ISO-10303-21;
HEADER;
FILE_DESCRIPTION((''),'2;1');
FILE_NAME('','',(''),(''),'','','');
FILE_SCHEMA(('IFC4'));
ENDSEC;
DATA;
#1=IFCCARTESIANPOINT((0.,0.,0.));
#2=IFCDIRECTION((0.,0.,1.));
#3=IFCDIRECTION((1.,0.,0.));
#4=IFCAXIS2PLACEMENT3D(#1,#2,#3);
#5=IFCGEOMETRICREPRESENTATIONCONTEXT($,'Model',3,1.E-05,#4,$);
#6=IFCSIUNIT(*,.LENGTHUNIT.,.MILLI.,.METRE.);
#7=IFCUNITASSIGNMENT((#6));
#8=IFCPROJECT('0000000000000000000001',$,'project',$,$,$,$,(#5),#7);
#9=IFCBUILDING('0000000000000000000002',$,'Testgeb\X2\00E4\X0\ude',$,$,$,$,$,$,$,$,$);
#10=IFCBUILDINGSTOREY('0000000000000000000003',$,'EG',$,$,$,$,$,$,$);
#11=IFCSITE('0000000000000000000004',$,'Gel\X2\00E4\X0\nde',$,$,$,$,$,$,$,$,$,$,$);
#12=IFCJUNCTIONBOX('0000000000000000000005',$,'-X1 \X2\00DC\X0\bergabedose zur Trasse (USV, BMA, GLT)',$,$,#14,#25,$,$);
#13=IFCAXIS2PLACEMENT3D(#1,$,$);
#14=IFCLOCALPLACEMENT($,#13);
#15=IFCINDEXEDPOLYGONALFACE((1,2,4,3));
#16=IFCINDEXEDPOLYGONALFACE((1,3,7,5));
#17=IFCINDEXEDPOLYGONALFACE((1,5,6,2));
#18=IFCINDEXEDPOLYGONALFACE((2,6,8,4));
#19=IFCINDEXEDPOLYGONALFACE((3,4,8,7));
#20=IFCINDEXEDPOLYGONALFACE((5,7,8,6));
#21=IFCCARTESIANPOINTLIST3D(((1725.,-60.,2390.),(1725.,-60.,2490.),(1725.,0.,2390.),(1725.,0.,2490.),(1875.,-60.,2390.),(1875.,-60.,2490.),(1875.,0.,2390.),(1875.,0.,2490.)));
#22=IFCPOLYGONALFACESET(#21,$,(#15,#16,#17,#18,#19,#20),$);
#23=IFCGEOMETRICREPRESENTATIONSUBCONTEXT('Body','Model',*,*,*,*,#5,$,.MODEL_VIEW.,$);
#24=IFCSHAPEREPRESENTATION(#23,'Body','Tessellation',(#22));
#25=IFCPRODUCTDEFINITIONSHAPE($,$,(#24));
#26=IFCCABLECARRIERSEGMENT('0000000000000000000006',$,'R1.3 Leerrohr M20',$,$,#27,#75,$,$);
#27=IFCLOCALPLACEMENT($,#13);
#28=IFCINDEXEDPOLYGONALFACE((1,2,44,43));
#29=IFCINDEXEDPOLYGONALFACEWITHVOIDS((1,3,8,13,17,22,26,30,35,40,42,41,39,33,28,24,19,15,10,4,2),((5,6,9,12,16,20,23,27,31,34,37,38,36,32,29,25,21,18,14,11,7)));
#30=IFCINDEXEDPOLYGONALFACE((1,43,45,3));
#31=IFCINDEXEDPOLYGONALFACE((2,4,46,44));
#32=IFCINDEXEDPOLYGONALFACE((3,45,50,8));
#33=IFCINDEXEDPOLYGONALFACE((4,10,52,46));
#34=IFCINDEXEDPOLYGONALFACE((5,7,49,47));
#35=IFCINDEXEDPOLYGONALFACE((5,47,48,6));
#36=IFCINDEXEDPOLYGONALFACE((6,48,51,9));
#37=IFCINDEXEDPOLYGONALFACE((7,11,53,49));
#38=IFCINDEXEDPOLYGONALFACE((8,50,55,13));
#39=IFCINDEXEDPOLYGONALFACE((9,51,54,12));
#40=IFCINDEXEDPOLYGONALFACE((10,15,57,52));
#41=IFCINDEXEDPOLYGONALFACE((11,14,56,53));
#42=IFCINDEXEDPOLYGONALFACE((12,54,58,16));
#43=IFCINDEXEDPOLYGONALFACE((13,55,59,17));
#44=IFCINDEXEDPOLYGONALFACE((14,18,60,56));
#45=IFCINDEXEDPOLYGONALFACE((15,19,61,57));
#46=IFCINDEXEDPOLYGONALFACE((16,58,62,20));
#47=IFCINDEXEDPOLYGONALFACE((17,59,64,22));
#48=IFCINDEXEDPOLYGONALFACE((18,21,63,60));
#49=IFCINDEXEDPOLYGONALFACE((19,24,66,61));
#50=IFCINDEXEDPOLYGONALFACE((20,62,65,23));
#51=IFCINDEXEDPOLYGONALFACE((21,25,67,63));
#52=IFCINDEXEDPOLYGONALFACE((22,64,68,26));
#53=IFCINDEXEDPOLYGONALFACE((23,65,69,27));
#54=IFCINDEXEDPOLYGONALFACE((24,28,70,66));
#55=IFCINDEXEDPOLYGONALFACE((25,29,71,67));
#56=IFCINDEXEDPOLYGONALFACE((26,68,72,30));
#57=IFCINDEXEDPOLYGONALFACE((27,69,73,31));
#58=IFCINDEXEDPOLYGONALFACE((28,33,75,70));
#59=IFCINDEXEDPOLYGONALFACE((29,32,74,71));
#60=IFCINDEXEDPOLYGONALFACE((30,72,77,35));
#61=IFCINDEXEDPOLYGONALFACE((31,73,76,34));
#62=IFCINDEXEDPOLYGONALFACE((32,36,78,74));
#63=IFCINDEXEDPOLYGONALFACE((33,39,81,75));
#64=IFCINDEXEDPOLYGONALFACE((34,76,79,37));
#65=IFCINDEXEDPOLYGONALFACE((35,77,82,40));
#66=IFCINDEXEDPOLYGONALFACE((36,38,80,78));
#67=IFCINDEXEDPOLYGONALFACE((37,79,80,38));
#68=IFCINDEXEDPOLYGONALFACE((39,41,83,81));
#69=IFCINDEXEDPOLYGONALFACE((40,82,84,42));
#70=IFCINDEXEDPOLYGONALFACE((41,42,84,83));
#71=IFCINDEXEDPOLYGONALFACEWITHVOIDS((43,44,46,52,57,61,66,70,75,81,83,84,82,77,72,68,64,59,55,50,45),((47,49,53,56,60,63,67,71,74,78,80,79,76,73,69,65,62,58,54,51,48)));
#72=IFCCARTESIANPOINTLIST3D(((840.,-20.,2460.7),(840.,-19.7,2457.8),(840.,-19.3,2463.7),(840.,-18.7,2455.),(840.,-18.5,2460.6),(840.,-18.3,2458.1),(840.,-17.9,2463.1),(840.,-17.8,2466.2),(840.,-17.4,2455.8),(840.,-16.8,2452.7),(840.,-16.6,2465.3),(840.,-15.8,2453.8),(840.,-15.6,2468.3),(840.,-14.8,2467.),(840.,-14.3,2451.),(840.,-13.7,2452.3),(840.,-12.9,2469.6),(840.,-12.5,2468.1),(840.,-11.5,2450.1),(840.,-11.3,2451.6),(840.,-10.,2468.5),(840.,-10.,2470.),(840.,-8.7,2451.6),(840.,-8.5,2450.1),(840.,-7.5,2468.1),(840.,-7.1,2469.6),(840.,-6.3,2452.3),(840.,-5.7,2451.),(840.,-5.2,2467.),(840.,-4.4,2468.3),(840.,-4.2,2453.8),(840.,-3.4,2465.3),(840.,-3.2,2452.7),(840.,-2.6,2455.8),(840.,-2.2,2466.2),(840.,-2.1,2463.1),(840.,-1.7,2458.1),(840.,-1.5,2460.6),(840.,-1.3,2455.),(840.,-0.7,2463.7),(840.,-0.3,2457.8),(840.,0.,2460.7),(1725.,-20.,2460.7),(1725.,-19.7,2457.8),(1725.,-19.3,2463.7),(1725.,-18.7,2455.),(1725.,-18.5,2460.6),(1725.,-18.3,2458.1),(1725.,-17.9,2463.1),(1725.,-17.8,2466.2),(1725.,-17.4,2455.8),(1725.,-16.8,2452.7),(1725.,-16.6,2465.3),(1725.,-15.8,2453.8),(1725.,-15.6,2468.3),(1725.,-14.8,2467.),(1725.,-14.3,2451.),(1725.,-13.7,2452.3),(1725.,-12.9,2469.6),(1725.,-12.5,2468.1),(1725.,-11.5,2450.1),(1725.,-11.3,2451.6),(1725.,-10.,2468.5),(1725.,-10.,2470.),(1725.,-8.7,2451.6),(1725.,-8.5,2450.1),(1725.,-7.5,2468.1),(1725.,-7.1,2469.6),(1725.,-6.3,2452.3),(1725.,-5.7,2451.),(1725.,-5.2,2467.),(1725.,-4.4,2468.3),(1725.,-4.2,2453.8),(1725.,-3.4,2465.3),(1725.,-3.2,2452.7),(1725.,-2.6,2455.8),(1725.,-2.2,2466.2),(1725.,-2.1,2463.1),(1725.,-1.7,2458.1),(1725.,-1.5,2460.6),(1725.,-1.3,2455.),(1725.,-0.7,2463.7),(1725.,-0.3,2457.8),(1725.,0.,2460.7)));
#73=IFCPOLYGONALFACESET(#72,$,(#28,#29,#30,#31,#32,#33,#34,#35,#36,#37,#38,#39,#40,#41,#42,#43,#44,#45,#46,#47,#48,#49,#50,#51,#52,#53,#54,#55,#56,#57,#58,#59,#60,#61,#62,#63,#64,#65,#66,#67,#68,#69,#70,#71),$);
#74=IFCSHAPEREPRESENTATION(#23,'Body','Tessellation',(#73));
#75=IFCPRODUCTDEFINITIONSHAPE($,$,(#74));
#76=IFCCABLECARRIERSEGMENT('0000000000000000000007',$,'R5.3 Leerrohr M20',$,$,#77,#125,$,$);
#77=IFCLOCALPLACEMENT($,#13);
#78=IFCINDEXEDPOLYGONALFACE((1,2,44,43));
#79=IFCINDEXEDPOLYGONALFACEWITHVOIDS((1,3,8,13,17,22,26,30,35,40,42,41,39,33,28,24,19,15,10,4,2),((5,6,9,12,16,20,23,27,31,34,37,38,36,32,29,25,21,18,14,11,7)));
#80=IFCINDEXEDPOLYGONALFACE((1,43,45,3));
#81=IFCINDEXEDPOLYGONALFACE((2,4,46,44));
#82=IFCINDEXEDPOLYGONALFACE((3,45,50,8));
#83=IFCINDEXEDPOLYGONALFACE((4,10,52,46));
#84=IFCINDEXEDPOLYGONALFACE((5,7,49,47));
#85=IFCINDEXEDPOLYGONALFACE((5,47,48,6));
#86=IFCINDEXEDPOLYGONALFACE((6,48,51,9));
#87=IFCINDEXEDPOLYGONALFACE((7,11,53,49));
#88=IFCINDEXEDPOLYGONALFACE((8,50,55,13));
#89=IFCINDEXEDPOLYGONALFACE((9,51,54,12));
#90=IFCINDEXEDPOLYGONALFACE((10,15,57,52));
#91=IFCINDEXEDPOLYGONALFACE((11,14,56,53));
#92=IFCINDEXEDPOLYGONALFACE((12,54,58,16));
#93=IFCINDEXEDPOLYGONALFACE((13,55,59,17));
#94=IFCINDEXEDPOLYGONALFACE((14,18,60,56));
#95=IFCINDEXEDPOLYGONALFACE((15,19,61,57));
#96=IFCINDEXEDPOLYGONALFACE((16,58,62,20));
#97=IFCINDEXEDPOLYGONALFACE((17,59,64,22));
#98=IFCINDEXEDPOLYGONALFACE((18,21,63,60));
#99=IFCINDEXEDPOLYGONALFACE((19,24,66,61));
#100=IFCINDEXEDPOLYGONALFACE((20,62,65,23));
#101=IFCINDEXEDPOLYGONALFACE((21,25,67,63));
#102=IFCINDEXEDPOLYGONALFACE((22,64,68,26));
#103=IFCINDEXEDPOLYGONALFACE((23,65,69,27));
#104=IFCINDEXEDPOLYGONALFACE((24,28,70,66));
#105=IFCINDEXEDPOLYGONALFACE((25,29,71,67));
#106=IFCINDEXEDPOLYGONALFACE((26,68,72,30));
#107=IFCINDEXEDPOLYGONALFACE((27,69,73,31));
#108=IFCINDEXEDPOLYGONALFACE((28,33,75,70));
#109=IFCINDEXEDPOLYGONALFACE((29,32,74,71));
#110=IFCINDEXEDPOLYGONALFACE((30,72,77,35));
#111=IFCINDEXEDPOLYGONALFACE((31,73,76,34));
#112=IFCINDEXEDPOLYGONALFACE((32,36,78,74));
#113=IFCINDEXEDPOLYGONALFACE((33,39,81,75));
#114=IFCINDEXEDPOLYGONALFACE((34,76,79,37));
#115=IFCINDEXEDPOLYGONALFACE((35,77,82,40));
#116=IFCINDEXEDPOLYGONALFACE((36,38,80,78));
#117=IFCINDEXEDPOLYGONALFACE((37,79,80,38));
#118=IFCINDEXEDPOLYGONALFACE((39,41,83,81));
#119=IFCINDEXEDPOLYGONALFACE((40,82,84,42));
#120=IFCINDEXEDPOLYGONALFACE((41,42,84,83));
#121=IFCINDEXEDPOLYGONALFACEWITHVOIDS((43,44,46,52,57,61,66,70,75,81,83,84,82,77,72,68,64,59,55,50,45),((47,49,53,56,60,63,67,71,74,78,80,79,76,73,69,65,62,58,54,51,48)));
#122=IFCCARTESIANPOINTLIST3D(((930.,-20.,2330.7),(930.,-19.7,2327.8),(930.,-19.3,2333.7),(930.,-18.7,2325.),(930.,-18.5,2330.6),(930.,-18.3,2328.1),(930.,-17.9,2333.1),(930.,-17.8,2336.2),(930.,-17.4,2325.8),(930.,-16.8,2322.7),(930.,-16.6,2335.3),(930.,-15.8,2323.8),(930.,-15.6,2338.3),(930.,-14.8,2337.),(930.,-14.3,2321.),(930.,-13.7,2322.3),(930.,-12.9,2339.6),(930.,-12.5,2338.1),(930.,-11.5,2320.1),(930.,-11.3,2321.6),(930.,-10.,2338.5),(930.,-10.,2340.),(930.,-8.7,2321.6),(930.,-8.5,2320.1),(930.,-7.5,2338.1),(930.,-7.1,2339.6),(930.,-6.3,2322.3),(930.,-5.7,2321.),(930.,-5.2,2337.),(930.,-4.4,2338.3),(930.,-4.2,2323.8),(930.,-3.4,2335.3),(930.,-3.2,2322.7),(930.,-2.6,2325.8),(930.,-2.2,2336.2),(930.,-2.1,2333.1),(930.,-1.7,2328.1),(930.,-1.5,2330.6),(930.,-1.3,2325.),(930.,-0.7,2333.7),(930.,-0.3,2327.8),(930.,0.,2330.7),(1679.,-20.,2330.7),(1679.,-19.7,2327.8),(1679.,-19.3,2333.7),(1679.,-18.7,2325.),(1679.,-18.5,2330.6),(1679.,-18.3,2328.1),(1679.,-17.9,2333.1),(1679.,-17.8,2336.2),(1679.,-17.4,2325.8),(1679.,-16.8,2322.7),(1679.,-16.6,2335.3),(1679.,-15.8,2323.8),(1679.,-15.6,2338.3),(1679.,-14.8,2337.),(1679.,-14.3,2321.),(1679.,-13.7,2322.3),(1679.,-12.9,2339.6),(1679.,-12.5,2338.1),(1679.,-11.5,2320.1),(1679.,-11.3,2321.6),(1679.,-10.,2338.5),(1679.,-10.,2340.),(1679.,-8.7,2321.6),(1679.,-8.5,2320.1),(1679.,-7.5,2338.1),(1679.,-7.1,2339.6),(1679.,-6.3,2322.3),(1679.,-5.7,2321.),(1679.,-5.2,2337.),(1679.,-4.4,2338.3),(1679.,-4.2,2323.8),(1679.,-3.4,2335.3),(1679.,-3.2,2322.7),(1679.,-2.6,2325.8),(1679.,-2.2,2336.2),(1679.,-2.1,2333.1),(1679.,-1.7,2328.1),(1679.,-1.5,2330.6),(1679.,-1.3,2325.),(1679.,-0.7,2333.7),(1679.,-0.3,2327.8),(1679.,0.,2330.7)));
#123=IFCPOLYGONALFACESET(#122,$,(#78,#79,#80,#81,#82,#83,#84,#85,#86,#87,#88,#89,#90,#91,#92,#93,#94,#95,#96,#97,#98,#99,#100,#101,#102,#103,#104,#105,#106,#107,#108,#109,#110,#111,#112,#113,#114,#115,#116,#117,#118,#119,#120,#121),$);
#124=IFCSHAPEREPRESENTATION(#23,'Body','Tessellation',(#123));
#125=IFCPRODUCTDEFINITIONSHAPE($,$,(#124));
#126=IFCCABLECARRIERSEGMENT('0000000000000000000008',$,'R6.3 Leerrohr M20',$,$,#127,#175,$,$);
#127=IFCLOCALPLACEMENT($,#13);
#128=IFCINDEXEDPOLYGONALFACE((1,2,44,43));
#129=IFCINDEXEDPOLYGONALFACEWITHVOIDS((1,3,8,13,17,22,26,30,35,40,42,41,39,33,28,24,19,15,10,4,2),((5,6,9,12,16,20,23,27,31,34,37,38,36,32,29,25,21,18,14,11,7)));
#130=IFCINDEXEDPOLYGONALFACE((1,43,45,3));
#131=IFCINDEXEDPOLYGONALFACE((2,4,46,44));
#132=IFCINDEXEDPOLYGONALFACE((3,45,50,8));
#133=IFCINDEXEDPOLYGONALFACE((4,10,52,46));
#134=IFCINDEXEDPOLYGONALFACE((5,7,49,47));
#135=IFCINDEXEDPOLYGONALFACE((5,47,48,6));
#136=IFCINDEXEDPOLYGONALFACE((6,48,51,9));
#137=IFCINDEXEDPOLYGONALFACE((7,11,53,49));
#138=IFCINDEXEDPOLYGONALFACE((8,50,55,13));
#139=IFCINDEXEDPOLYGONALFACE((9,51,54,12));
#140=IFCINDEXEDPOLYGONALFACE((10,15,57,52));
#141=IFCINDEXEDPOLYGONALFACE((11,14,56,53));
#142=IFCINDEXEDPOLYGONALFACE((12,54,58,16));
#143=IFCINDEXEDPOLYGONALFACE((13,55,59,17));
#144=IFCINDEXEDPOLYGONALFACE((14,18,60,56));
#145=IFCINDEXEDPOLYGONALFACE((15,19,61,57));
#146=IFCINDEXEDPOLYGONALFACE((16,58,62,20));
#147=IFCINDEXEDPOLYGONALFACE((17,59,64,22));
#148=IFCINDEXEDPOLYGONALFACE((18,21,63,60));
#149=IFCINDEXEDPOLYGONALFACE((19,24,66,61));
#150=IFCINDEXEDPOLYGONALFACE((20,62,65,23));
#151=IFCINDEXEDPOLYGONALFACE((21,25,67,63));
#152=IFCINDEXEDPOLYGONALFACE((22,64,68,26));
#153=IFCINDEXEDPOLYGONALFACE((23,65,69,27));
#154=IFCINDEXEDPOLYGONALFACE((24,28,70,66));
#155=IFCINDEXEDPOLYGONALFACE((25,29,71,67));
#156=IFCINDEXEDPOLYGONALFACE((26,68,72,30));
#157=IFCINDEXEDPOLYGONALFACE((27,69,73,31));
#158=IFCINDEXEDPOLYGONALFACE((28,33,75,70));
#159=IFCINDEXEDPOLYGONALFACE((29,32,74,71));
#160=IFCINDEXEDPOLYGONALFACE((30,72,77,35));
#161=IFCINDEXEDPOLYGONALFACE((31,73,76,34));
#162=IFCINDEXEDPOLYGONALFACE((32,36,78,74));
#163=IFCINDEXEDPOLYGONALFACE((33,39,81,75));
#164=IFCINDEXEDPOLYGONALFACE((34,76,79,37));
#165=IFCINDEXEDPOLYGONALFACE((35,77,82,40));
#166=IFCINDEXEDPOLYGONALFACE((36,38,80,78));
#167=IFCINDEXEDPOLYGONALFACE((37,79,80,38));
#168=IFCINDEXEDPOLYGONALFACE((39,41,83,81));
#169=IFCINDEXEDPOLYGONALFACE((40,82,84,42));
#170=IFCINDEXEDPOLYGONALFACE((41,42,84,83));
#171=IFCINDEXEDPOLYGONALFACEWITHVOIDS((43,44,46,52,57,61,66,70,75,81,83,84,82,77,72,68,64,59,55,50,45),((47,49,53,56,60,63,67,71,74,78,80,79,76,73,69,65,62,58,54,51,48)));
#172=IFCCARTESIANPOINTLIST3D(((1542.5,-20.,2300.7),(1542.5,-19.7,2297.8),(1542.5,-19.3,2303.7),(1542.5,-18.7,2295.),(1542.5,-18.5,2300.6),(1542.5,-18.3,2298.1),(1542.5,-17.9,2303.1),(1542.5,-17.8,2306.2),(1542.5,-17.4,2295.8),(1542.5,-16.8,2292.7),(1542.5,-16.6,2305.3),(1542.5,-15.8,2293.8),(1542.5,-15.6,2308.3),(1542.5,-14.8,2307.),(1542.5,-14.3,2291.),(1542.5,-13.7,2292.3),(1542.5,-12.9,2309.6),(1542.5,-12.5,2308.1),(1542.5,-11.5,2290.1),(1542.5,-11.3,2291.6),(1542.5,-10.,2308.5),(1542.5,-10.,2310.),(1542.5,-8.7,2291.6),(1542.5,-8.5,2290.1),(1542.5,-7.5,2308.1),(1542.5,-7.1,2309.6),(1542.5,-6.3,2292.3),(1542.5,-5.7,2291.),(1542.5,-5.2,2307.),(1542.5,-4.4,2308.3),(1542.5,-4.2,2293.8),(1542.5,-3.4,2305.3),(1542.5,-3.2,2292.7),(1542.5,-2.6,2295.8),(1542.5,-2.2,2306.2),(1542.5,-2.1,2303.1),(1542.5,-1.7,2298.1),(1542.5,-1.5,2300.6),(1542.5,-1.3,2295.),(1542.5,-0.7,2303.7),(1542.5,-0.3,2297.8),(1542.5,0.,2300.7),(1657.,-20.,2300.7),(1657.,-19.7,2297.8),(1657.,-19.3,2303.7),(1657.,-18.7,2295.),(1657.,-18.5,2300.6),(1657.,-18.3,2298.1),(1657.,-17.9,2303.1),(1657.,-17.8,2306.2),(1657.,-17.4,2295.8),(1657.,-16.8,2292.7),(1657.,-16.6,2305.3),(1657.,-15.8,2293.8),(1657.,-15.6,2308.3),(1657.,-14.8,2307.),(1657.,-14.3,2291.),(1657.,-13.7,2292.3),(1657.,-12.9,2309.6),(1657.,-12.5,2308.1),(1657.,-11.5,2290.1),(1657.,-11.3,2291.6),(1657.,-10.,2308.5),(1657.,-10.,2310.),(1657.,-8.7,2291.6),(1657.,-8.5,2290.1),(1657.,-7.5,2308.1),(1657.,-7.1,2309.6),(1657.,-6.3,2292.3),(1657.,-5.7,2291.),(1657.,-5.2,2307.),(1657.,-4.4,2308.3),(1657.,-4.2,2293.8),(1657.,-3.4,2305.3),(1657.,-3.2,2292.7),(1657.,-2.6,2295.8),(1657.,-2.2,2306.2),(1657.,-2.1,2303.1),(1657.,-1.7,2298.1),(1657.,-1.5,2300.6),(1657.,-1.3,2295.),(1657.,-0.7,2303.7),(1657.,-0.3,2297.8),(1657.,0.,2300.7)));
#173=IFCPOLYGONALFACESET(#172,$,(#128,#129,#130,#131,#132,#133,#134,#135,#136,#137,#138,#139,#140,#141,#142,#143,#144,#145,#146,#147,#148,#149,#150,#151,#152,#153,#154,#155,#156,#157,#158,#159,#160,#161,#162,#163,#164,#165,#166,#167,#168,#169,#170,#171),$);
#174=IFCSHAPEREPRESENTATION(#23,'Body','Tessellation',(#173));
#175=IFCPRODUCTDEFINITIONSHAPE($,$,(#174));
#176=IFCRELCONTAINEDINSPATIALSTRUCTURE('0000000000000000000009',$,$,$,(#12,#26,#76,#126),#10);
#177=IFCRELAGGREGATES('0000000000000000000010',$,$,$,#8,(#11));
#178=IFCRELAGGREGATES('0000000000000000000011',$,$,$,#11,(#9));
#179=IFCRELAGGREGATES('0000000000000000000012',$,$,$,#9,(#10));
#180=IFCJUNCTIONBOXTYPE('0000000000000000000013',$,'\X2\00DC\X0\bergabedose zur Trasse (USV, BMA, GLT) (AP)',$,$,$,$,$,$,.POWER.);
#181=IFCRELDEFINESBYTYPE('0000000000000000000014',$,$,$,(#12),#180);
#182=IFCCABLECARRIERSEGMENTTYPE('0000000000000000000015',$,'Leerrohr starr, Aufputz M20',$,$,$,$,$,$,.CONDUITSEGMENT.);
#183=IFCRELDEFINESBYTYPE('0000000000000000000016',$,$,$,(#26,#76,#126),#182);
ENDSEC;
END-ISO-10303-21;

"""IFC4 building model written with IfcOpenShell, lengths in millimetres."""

from ifc_helpers import new_model, si_unit, frame, frame_2d, origin_with_axes, place, context, subcontext, project, spatial, rectangle, hollow_circle, extrude, type_object, element, save


model = new_model("IFC4")

# Units and contexts
model_context = context("Model", 3, precision=1e-05, world=origin_with_axes())
body_context = subcontext(model_context, "Body", "Model", "MODEL_VIEW")
ifc_project = project(units=[si_unit("LENGTHUNIT", "METRE", prefix="MILLI")], contexts=[model_context])

# Site, building, storey
site = spatial("IfcSite", under=ifc_project, Name="Gelände")
building = spatial("IfcBuilding", under=site, Name="Testgebäude")
storey = spatial("IfcBuildingStorey", under=building, Name="EG")

# Junction box
junction_box_type = type_object("IfcJunctionBoxType", Name="Übergabedose zur Trasse (USV, BMA, GLT) (AP)", PredefinedType="POWER")
junction_box_placement = place(None, frame((1725.0, -60.0, 2390.0), z_axis=(0.0, 0.0, 1.0), x_axis=(1.0, 0.0, 0.0)))
element("IfcJunctionBox", 1, at=junction_box_placement, inside=storey, type_object=junction_box_type, Name="-X1 Übergabedose zur Trasse (USV, BMA, GLT)", context=body_context, shape_type="SweptSolid", body=[
    extrude(rectangle(XDim=150.0, YDim=60.0, at=frame_2d((75.0, 30.0))), None, (0.0, 0.0, 1.0), 100.0),
])

# Cable carrier segments
cable_carrier_segment_type_1 = type_object("IfcCableCarrierSegmentType", Name="Leerrohr starr, Aufputz M20", PredefinedType="CONDUITSEGMENT")
cable_carrier_segment_1_placement = place(None, frame((840.0, -10.0, 2460.0), z_axis=(1.0, 0.0, 0.0), x_axis=(0.0, 0.0, 1.0)))
element("IfcCableCarrierSegment", 2, at=cable_carrier_segment_1_placement, inside=storey, type_object=cable_carrier_segment_type_1, Name="R1.3 Leerrohr M20", context=body_context, shape_type="SweptSolid", body=[
    extrude(hollow_circle(Radius=10.0, WallThickness=1.5), None, (0.0, 0.0, 1.0), 885.0),
])
cable_carrier_segment_2_placement = place(None, frame((930.0, -10.0, 2330.0), z_axis=(1.0, 0.0, 0.0), x_axis=(0.0, 0.0, 1.0)))
element("IfcCableCarrierSegment", 3, at=cable_carrier_segment_2_placement, inside=storey, type_object=cable_carrier_segment_type_1, Name="R5.3 Leerrohr M20", context=body_context, shape_type="SweptSolid", body=[
    extrude(hollow_circle(Radius=10.0, WallThickness=1.5), None, (0.0, 0.0, 1.0), 749.0),
])
cable_carrier_segment_3_placement = place(None, frame((1542.5, -10.0, 2300.0), z_axis=(1.0, 0.0, 0.0), x_axis=(0.0, 0.0, 1.0)))
element("IfcCableCarrierSegment", 4, at=cable_carrier_segment_3_placement, inside=storey, type_object=cable_carrier_segment_type_1, Name="R6.3 Leerrohr M20", context=body_context, shape_type="SweptSolid", body=[
    extrude(hollow_circle(Radius=10.0, WallThickness=1.5), None, (0.0, 0.0, 1.0), 114.5),
])

save(model, "model.ifc")
